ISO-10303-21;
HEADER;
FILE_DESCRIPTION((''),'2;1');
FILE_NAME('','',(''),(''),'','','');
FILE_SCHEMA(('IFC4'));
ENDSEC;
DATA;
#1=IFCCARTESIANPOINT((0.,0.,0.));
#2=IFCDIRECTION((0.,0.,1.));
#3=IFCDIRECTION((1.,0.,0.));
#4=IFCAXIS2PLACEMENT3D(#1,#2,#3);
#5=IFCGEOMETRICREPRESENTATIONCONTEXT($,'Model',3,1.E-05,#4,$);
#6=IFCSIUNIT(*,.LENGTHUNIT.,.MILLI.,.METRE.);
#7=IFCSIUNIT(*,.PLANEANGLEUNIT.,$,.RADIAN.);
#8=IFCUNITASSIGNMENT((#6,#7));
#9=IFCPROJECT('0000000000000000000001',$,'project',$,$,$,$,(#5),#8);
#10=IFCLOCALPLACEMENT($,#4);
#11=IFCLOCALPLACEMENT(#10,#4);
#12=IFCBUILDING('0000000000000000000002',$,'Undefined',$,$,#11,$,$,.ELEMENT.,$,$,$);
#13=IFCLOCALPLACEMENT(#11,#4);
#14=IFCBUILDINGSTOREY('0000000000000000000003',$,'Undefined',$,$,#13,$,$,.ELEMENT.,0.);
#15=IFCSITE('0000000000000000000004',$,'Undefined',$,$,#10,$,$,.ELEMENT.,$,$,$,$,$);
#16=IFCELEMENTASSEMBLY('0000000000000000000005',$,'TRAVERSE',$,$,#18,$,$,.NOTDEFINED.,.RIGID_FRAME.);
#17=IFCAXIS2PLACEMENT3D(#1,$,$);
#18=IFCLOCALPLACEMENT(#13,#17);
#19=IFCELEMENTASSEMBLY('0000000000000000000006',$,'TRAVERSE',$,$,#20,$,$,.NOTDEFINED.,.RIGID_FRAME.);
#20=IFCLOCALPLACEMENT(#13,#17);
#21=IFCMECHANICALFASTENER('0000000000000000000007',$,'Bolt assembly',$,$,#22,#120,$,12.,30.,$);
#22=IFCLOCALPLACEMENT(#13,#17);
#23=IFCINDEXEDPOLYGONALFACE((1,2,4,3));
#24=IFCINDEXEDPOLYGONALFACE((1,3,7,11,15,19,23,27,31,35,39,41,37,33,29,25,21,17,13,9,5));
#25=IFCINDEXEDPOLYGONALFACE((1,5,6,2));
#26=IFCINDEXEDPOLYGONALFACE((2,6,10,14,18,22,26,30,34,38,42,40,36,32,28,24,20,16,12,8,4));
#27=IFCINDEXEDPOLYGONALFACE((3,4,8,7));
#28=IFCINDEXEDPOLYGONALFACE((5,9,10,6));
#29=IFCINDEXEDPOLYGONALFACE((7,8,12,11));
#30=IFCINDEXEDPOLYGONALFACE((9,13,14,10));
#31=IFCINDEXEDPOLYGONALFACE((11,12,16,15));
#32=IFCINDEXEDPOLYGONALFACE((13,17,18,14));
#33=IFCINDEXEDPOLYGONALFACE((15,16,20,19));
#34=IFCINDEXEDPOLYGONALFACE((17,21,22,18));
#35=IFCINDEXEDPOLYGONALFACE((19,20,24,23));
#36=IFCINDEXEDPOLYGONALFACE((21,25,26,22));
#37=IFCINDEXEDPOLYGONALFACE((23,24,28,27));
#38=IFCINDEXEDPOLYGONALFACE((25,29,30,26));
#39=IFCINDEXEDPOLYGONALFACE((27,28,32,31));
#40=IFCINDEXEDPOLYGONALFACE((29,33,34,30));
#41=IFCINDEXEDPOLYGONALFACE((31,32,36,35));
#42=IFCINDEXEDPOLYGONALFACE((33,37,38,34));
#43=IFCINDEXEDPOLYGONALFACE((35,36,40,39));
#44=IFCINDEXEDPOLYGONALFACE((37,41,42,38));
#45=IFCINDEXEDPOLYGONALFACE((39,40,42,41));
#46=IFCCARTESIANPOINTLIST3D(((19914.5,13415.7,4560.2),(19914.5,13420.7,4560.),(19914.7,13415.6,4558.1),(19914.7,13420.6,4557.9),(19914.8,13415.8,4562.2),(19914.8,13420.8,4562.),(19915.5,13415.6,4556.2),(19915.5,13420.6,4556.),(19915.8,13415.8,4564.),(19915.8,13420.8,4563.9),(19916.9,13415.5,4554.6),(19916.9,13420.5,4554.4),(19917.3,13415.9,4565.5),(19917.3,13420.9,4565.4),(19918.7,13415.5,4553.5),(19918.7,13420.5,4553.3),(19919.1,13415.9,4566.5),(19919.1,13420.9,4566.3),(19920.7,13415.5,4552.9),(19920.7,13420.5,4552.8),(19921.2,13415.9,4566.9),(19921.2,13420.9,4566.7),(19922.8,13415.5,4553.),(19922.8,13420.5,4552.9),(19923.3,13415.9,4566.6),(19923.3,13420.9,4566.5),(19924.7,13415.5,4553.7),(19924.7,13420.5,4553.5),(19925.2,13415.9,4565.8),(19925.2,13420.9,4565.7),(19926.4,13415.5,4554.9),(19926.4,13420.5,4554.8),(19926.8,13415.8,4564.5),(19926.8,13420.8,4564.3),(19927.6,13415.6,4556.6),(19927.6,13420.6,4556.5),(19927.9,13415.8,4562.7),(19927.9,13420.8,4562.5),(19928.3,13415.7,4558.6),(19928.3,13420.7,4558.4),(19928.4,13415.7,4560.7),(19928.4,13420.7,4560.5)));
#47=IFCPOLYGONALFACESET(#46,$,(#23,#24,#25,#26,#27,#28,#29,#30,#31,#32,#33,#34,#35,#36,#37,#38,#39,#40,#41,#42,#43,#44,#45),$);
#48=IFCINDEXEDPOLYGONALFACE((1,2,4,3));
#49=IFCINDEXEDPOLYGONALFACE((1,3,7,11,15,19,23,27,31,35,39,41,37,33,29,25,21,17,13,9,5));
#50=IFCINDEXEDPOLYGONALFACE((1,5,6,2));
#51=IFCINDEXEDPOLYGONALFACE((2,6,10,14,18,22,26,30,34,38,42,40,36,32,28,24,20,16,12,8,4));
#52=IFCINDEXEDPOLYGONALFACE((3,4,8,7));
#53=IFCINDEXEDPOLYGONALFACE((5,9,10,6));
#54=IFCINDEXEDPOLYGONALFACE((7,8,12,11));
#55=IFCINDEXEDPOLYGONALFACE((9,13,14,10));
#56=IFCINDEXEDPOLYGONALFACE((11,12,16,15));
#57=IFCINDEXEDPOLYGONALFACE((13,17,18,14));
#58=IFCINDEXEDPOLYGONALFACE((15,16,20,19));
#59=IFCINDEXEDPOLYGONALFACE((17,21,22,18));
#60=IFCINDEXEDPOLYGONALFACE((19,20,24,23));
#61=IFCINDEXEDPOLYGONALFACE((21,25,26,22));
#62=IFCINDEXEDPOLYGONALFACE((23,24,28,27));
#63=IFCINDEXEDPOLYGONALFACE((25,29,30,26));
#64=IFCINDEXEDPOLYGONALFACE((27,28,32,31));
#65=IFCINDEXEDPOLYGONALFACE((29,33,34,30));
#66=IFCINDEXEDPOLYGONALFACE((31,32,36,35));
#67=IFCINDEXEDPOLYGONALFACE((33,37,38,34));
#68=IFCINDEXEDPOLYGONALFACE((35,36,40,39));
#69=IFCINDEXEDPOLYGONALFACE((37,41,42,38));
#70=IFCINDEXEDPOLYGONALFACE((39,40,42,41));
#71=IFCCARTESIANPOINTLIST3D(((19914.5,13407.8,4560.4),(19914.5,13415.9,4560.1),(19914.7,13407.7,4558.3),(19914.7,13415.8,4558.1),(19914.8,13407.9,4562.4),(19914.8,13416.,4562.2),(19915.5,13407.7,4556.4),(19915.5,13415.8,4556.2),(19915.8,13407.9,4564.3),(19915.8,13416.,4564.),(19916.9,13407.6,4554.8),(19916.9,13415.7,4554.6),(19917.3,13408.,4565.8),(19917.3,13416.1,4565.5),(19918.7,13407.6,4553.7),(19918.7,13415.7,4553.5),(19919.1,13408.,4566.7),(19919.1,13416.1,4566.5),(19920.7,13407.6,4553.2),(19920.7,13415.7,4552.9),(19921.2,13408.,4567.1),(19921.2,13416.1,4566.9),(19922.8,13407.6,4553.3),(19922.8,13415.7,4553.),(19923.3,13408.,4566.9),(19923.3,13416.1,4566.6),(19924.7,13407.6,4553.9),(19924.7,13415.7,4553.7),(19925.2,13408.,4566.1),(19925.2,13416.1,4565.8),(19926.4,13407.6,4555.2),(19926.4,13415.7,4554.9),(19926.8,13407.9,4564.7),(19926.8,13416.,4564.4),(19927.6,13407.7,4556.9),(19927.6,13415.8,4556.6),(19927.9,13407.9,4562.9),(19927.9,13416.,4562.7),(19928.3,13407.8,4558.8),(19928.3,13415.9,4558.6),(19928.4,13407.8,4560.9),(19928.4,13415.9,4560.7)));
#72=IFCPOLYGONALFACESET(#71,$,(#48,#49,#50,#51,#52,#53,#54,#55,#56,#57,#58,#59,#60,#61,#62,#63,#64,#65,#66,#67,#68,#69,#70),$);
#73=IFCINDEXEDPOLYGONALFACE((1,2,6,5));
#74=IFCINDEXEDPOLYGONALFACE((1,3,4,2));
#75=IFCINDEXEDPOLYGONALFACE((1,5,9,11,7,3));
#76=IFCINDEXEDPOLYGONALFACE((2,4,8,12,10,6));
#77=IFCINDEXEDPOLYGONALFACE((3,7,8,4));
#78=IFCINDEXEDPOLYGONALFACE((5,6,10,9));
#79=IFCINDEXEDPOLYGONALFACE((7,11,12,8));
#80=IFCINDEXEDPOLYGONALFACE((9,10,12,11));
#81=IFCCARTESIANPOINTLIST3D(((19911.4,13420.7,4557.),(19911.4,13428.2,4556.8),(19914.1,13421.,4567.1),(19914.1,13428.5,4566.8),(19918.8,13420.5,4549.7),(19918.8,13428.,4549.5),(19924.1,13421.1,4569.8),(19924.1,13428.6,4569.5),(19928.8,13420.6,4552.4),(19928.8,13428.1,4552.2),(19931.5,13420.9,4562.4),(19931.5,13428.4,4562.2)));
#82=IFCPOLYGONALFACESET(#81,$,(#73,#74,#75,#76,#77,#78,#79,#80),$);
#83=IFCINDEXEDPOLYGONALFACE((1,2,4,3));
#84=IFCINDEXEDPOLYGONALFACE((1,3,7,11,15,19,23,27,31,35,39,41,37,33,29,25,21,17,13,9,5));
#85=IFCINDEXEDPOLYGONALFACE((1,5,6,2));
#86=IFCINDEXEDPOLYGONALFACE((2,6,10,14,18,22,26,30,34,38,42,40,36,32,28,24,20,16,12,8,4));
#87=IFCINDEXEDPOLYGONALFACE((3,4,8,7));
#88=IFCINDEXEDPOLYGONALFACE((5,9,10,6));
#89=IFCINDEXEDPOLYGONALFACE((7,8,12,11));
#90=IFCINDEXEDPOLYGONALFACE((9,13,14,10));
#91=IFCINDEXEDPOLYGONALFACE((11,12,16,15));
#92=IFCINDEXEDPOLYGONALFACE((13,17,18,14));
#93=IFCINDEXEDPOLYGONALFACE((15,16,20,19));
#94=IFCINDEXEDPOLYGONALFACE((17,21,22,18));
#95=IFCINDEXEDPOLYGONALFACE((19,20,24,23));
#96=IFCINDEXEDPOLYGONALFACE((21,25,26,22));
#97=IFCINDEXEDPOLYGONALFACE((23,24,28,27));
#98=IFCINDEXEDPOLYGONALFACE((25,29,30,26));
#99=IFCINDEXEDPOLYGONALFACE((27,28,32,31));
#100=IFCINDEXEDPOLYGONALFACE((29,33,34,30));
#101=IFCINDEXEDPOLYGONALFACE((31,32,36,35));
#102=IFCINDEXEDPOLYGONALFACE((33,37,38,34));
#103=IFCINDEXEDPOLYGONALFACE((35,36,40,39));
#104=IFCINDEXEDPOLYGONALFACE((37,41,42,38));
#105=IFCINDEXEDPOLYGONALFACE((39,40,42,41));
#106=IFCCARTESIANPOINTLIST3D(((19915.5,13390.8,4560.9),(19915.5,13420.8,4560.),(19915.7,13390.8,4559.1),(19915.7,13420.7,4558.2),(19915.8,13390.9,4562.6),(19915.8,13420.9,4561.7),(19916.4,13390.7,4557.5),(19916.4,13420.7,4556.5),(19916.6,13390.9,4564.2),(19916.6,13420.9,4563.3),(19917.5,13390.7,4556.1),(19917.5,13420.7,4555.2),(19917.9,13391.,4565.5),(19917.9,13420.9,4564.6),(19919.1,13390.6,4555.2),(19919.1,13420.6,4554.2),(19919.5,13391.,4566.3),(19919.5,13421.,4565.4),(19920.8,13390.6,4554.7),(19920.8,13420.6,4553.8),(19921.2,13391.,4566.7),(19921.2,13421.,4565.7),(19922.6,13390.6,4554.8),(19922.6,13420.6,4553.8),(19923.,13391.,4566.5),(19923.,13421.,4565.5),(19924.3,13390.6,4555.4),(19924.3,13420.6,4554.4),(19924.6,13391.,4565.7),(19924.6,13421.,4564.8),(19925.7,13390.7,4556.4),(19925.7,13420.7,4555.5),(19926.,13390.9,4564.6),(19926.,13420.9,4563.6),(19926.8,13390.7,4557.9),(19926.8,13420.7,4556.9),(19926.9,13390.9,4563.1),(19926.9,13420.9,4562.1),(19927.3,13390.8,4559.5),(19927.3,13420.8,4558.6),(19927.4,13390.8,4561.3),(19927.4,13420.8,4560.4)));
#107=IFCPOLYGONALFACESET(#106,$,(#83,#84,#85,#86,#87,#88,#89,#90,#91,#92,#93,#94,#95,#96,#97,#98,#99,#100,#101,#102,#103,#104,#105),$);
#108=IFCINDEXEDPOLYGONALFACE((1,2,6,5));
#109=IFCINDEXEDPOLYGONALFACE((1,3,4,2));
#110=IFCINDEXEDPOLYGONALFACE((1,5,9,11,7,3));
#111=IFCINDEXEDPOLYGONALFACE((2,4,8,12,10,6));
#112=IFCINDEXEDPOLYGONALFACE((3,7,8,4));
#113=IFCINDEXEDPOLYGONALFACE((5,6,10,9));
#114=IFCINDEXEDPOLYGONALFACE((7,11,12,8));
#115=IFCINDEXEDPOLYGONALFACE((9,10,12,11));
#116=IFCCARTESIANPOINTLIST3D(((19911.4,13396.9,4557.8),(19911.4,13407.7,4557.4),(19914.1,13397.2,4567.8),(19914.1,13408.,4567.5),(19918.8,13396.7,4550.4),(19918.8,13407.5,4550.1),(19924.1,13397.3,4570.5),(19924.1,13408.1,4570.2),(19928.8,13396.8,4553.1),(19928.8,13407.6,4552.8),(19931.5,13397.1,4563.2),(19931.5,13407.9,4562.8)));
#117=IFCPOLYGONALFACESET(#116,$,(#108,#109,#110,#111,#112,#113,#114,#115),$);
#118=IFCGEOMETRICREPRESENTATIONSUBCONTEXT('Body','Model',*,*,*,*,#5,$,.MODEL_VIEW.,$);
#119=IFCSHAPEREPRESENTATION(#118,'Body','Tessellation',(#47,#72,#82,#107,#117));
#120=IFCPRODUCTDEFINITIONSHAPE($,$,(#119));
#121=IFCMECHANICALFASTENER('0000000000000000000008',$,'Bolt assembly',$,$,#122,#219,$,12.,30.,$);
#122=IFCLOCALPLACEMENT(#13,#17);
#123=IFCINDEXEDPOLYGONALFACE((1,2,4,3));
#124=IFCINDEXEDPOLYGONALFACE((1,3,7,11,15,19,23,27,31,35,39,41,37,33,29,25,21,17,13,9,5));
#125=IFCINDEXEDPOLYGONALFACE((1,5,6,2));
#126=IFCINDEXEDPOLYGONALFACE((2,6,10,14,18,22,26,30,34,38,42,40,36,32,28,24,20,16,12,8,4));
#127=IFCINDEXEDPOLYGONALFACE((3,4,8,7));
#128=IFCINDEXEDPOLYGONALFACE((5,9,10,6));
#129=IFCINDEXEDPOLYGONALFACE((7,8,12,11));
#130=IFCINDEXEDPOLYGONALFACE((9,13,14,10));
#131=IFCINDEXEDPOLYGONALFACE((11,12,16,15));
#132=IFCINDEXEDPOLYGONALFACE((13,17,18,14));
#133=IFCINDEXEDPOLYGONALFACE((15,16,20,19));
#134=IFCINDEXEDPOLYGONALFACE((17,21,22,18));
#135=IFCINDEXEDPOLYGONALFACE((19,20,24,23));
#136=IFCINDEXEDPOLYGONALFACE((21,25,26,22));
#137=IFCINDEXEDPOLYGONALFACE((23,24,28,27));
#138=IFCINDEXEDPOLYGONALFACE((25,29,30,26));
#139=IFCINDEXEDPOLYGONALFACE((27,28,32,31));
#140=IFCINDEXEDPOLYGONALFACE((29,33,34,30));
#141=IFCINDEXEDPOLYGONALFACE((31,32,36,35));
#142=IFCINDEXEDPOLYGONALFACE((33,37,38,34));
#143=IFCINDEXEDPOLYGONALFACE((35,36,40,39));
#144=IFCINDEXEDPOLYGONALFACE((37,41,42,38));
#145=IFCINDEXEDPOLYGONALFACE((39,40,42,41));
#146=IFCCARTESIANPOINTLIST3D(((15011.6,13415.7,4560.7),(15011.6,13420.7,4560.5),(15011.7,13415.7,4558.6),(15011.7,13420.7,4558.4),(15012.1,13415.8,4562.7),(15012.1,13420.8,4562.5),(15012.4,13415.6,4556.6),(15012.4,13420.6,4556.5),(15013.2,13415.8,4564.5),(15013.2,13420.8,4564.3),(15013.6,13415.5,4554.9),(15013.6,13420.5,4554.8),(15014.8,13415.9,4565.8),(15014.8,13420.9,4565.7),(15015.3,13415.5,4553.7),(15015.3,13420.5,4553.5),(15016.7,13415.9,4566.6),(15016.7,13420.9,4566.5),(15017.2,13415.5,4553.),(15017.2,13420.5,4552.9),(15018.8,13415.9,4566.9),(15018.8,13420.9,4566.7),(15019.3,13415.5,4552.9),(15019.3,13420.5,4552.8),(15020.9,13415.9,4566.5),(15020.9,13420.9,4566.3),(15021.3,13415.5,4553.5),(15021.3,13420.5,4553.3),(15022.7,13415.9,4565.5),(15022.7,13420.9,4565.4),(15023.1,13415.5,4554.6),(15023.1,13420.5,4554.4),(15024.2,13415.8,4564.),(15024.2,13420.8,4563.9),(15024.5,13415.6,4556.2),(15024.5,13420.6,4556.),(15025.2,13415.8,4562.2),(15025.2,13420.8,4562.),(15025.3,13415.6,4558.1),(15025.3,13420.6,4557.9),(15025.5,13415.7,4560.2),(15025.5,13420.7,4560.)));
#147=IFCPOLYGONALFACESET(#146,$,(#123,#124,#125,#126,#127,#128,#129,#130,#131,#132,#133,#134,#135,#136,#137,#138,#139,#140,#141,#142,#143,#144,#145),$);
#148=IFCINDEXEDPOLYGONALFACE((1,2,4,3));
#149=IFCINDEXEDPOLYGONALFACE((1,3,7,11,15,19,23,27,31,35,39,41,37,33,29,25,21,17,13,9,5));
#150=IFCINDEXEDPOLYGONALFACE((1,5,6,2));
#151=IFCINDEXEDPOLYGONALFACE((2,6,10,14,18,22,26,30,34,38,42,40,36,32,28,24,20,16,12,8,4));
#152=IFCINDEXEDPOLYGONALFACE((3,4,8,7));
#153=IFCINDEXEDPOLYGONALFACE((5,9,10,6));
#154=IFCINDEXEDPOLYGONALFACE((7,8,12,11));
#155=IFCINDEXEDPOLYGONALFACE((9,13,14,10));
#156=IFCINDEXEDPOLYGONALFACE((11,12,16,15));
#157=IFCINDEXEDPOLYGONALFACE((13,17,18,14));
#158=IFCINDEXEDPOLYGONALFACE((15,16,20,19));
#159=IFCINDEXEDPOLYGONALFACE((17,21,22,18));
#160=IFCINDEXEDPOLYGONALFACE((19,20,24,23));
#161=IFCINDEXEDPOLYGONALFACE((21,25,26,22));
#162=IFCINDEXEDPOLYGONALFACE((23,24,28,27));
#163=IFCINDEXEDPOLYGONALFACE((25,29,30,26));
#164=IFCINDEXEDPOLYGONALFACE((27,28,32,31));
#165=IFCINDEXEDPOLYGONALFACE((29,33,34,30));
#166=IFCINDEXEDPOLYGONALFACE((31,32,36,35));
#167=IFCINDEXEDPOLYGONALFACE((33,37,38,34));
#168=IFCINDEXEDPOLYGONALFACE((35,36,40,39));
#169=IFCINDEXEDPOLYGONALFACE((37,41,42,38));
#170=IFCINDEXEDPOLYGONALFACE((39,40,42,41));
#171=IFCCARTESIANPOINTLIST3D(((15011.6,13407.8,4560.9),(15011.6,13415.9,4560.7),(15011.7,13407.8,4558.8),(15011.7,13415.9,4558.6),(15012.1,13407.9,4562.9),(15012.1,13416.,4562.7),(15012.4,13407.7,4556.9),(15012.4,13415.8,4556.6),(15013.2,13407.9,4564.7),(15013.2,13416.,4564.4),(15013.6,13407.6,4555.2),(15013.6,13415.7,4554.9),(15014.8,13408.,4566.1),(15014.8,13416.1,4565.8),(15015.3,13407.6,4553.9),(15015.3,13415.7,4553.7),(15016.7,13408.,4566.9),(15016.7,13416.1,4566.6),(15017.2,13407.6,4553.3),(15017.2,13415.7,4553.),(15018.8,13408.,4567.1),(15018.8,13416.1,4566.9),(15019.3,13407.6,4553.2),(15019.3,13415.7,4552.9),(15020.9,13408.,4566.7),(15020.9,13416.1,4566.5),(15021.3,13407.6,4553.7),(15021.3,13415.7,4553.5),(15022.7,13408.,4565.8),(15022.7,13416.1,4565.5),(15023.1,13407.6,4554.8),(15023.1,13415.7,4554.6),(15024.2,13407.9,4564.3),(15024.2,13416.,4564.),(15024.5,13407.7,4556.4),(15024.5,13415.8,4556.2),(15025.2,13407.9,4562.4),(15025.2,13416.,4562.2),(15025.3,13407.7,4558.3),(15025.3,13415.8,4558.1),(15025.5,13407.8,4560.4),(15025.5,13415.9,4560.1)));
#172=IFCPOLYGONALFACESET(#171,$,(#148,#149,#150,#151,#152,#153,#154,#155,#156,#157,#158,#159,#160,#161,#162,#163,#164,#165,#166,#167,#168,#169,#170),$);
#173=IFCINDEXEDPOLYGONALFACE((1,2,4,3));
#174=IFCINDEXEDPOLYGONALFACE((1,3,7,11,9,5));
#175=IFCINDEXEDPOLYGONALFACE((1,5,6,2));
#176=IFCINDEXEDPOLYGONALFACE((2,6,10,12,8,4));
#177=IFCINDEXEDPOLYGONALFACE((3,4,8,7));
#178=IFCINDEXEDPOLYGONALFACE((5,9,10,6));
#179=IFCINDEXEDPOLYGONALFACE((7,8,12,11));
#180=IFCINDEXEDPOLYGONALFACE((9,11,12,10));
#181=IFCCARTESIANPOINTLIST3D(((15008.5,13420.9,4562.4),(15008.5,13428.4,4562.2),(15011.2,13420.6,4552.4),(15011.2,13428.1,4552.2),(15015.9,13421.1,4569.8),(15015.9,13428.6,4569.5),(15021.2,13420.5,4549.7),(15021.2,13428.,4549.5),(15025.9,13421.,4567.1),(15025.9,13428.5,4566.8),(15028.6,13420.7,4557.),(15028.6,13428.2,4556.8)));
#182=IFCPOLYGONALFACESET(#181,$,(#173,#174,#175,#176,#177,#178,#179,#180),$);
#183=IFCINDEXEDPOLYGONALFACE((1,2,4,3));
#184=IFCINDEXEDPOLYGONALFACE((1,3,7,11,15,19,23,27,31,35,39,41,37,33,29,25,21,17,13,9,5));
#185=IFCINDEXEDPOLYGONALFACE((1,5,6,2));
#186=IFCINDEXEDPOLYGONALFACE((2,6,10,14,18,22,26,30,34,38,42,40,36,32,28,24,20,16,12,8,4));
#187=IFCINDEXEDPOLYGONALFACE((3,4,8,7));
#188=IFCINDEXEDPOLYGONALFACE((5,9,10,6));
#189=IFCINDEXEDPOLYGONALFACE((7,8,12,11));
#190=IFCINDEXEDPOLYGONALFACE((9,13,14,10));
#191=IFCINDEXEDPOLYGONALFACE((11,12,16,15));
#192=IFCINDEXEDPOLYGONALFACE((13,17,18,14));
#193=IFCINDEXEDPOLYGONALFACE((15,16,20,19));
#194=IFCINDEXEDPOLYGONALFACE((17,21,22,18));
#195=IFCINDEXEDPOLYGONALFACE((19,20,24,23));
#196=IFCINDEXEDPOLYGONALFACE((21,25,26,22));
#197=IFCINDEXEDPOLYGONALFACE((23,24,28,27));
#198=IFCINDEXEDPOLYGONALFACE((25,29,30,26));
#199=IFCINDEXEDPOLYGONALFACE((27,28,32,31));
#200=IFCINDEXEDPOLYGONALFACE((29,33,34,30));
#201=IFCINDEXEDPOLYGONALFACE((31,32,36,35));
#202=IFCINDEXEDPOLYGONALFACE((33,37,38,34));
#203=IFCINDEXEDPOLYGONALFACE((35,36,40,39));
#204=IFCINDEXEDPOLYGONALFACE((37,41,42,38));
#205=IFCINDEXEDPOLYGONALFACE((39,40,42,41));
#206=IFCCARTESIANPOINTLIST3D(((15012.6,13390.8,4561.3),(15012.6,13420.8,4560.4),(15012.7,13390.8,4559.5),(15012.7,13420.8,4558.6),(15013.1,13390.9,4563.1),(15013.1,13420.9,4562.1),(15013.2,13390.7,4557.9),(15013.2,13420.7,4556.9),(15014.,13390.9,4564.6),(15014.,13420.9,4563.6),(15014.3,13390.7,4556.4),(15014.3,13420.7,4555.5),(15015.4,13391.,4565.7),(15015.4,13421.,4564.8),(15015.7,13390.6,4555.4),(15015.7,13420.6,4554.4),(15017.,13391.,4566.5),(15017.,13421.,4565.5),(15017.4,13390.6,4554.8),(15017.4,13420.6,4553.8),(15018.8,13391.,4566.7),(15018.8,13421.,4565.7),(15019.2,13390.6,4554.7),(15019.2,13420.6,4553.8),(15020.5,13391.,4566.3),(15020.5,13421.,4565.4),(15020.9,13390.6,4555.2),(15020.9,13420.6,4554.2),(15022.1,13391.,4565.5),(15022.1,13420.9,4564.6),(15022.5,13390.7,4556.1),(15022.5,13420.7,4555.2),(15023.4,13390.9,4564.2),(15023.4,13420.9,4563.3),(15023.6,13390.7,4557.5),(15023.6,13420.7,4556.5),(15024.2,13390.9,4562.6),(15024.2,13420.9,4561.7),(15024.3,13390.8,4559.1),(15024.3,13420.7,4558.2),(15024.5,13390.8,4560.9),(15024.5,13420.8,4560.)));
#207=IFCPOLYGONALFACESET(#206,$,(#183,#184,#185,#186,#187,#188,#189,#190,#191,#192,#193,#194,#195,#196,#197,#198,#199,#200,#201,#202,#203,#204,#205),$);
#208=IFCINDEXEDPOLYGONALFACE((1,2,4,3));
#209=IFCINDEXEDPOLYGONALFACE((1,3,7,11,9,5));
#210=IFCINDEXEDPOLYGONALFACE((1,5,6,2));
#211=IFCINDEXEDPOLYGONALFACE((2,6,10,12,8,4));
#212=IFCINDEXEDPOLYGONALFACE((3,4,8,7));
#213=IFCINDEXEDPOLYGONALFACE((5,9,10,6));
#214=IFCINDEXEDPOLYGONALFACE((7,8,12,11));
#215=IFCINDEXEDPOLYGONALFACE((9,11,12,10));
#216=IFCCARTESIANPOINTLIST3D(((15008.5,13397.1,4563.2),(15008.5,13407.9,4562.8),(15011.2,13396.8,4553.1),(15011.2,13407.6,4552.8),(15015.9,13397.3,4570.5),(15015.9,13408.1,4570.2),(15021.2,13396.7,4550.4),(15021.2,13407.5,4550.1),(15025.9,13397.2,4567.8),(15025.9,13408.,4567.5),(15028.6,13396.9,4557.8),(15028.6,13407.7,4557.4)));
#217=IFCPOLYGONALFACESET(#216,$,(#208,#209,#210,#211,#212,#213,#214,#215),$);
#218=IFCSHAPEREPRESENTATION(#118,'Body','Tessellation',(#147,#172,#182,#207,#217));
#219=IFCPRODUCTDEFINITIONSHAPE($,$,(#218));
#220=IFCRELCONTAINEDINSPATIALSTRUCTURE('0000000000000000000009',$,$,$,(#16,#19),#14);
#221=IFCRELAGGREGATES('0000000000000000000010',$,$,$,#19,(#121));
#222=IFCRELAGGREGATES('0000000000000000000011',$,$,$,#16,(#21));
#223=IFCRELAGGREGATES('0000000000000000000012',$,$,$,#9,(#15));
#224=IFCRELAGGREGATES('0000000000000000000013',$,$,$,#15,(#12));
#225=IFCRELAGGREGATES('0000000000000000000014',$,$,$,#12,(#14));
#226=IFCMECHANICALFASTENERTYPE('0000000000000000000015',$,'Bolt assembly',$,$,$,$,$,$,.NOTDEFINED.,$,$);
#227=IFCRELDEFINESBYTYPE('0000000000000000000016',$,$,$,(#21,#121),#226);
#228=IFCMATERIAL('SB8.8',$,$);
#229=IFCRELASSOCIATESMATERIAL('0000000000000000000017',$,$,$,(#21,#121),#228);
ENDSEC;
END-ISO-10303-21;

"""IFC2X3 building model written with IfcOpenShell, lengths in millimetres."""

from ifc_helpers import new_model, si_unit, frame, origin_with_axes, origin_2d_with_axis, place, context, subcontext, project, spatial, polyline, circle, outline, extrude, source, transform, mapped, material, type_object, element, aggregate, save


model = new_model("IFC2X3")

# Units and contexts
model_context = context("Model", 3, precision=1e-05, world=origin_with_axes())
body_context = subcontext(model_context, "Body", "Model", "MODEL_VIEW")
ifc_project = project(units=[si_unit("LENGTHUNIT", "METRE", prefix="MILLI"), si_unit("PLANEANGLEUNIT", "RADIAN")], contexts=[model_context])

# Site, building, storey
site_placement = place(None, origin_with_axes())
site = spatial("IfcSite", under=ifc_project, at=site_placement, Name="Undefined", CompositionType="ELEMENT")
building_placement = place(site_placement, origin_with_axes())
building = spatial("IfcBuilding", under=site, at=building_placement, Name="Undefined", CompositionType="ELEMENT")
storey_placement = place(building_placement, origin_with_axes())
storey = spatial("IfcBuildingStorey", under=building, at=storey_placement, Name="Undefined", CompositionType="ELEMENT", Elevation=0.0)

# Element assembly
assembly_1_placement = place(storey_placement, origin_with_axes())
assembly_1 = element("IfcElementAssembly", 1, at=assembly_1_placement, inside=storey, Name="TRAVERSE", AssemblyPlace="NOTDEFINED", PredefinedType="RIGID_FRAME")

# Element assembly
assembly_2_placement = place(storey_placement, origin_with_axes())
assembly_2 = element("IfcElementAssembly", 2, at=assembly_2_placement, inside=storey, Name="TRAVERSE", AssemblyPlace="NOTDEFINED", PredefinedType="RIGID_FRAME")

# Shared definitions
ifc_material_1 = material(Name="SB8.8")
mechanical_fastener_type = type_object("IfcMechanicalFastenerType", Name="Bolt assembly")

# Mechanical fasteners
shared_shape_1 = source(origin_with_axes(), body_context, "Body", "SweptSolid", [
    extrude(circle(Radius=7.0, at=origin_2d_with_axis()), frame((0.0, -4.9, 0.0), z_axis=(0.0, 1.0, 0.0), x_axis=(1.0, 0.0, 0.0)), (0.0, 0.0, 1.0), 5.0),
    extrude(circle(Radius=7.0, at=origin_2d_with_axis()), frame((0.0, -0.1, 0.0), z_axis=(0.0, 1.0, 0.0), x_axis=(1.0, 0.0, 0.0)), (0.0, 0.0, 1.0), 8.1),
    extrude(outline(polyline([(10.4, 0.0), (5.2, 9.0), (-5.2, 9.0), (-10.4, 0.0), (-5.2, -9.0), (5.2, -9.0), (10.4, 0.0)])), frame((0.0, -12.5, 0.0), z_axis=(0.0, 1.0, 0.0), x_axis=(1.0, 0.0, 0.0)), (0.0, 0.0, 1.0), 7.5),
    extrude(circle(Radius=6.0, at=origin_2d_with_axis()), frame((0.0, -5.0, 0.0), z_axis=(0.0, 1.0, 0.0), x_axis=(1.0, 0.0, 0.0)), (0.0, 0.0, 1.0), 30.0),
    extrude(outline(polyline([(10.4, 0.0), (5.2, 9.0), (-5.2, 9.0), (-10.4, 0.0), (-5.2, -9.0), (5.2, -9.0), (10.4, 0.0)])), frame((0.0, 8.0, 0.0), z_axis=(0.0, 1.0, 0.0), x_axis=(1.0, 0.0, 0.0)), (0.0, 0.0, 1.0), 10.8),
])
mechanical_fastener_1_placement = place(assembly_1_placement, frame((19921.5, 13415.8, 4559.9), z_axis=(-0.707107, -0.02191, -0.706767), x_axis=(0.707107, -0.02191, -0.706767)))
mechanical_fastener_1 = element("IfcMechanicalFastener", 3, at=mechanical_fastener_1_placement, type_object=mechanical_fastener_type, material=ifc_material_1, Name="Bolt assembly", NominalDiameter=12.0, NominalLength=30.0, context=body_context, shape_type="MappedRepresentation", body=[
    mapped(shared_shape_1, transform((0.0, 0.0, 0.0))),
])
mechanical_fastener_2_placement = place(assembly_2_placement, frame((15018.5, 13415.8, 4559.9), z_axis=(-0.707107, 0.02191, 0.706767), x_axis=(-0.707107, -0.02191, -0.706767)))
mechanical_fastener_2 = element("IfcMechanicalFastener", 4, at=mechanical_fastener_2_placement, type_object=mechanical_fastener_type, material=ifc_material_1, Name="Bolt assembly", NominalDiameter=12.0, NominalLength=30.0, context=body_context, shape_type="MappedRepresentation", body=[
    mapped(shared_shape_1, transform((0.0, 0.0, 0.0))),
])
aggregate(assembly_2, [mechanical_fastener_2])
aggregate(assembly_1, [mechanical_fastener_1])

save(model, "model.ifc")
